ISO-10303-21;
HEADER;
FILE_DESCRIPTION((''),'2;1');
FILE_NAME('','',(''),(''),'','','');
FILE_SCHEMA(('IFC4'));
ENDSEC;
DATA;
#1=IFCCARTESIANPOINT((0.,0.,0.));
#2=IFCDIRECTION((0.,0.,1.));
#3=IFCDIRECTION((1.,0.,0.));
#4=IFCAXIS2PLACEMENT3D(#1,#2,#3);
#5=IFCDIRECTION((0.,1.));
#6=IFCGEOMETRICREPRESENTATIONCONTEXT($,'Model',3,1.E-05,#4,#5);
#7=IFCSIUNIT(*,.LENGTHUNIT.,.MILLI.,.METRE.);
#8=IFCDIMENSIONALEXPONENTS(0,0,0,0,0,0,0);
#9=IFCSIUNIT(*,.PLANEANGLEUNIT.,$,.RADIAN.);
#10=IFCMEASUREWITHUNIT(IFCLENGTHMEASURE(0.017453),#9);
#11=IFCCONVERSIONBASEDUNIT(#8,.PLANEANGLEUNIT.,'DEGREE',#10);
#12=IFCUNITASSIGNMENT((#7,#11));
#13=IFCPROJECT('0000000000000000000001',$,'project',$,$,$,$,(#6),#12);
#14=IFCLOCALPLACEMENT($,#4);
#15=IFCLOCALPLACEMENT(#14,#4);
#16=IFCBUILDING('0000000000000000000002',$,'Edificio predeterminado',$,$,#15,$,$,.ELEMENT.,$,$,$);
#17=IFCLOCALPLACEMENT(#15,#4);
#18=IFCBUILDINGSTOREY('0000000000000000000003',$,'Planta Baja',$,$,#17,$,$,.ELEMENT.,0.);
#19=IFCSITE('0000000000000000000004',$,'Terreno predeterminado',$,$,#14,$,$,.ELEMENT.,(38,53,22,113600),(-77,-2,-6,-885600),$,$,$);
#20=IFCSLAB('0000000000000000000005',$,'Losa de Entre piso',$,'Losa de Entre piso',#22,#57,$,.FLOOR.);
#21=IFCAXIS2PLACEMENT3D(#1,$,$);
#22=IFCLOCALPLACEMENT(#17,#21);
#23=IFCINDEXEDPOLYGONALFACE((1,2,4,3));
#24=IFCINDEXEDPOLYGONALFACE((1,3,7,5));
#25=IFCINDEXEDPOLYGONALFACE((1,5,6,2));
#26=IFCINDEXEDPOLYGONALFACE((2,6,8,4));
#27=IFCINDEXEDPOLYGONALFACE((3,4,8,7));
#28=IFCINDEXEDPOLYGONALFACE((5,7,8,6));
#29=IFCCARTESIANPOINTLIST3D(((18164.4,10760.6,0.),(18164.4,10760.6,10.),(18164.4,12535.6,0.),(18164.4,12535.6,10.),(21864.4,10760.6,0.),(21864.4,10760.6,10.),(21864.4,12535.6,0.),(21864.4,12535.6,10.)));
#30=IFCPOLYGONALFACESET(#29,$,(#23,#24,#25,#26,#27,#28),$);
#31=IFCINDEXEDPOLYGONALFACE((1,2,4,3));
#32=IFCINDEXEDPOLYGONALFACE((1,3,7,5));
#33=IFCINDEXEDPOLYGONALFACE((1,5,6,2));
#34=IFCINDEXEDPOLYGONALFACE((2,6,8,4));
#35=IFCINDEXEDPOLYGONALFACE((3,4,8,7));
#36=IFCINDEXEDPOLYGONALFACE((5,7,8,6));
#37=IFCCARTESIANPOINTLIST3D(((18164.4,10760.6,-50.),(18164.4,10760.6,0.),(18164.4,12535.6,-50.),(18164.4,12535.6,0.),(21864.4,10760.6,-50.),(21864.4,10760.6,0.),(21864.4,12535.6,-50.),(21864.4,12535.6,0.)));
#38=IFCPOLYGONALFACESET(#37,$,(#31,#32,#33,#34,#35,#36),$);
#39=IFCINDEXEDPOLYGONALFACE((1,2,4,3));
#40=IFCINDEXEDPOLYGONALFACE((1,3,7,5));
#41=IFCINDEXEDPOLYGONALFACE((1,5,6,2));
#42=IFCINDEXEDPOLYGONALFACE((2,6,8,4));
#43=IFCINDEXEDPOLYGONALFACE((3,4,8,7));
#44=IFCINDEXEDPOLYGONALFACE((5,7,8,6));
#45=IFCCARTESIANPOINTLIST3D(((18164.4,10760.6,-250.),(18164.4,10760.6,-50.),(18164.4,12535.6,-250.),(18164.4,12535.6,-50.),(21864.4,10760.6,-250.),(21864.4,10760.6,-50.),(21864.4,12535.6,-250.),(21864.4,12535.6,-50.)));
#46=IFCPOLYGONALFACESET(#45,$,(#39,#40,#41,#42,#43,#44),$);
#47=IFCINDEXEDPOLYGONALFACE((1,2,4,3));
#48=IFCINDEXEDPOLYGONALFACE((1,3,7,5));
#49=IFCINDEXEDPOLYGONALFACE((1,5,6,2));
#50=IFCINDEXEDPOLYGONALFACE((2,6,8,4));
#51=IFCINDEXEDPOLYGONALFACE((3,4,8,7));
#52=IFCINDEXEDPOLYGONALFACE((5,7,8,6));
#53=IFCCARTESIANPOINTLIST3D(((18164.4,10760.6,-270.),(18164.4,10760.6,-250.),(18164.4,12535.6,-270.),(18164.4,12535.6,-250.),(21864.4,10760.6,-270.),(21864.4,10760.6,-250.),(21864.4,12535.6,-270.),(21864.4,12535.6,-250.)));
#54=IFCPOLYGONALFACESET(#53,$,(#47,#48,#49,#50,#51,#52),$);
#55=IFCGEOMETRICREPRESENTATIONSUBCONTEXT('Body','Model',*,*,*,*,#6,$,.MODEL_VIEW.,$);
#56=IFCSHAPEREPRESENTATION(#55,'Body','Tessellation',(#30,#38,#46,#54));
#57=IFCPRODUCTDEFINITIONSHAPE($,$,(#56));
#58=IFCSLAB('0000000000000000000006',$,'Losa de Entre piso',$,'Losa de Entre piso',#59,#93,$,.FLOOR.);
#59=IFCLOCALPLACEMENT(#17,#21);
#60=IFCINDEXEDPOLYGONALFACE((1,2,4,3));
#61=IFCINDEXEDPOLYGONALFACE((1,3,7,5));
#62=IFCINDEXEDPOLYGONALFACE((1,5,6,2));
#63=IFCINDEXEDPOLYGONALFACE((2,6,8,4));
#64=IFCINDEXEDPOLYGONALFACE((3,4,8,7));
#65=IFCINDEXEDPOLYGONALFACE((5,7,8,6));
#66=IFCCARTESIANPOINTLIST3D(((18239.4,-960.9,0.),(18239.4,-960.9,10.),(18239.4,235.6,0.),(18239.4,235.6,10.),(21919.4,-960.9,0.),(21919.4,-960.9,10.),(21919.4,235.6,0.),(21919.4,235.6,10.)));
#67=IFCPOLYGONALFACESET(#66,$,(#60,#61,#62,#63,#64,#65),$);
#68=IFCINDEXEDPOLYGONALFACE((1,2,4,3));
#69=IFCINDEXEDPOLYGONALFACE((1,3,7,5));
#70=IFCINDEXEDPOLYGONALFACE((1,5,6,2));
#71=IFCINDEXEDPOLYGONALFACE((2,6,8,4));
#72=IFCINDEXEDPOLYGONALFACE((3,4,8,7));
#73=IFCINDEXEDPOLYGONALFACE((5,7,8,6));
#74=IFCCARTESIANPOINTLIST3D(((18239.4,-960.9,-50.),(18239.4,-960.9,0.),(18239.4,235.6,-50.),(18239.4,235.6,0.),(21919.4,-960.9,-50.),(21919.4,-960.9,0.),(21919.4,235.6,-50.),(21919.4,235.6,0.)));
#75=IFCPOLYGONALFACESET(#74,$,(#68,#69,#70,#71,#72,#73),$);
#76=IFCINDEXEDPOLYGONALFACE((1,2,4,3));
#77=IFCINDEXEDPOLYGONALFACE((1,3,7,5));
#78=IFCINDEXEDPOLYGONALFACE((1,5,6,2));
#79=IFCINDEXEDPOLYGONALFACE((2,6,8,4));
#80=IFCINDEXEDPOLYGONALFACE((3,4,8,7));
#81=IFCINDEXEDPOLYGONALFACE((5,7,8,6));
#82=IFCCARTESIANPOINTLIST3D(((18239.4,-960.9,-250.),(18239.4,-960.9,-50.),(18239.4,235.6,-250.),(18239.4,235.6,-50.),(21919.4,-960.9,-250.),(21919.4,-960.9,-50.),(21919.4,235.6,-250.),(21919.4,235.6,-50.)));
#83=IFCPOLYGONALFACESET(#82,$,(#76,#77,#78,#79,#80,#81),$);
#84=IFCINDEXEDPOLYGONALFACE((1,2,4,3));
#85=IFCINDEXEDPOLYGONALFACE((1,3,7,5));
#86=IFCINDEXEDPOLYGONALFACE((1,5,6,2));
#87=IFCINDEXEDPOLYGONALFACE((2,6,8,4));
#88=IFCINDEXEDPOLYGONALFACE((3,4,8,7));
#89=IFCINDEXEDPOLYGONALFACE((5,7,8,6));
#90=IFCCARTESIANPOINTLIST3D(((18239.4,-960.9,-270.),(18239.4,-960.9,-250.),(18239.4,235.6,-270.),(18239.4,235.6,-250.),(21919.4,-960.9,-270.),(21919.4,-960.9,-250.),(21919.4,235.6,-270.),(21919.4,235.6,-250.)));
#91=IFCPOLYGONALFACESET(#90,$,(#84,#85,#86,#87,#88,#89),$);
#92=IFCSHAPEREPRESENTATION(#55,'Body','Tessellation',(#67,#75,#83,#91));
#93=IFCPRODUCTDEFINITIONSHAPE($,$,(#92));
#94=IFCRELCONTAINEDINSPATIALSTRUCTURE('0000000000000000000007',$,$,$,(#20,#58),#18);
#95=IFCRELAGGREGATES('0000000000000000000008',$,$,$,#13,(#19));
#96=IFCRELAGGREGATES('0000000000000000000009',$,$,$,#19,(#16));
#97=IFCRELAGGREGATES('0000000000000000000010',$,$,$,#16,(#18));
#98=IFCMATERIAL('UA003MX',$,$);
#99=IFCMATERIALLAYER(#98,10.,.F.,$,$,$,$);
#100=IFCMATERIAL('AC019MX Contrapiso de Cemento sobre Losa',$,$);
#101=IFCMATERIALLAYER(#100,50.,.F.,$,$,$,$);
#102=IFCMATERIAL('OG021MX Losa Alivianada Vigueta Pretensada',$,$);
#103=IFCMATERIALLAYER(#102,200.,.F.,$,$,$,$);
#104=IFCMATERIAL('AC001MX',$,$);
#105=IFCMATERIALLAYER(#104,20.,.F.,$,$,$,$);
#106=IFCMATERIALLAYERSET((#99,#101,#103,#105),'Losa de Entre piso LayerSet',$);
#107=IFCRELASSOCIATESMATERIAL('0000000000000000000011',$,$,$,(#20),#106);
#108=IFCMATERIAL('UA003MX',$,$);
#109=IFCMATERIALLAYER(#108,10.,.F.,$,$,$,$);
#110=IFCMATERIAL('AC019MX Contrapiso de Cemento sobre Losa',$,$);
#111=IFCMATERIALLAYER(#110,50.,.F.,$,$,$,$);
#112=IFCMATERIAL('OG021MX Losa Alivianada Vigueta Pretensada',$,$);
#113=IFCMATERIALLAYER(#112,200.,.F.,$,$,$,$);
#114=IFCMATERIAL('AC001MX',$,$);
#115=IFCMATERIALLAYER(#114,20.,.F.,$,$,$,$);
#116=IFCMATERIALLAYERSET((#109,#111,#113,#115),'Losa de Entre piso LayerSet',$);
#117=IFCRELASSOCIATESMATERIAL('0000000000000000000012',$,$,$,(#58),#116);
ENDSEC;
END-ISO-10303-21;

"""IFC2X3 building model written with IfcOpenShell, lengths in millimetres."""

from ifc_helpers import new_model, entity, si_unit, converted_unit, direction, frame, origin_with_axes, place, context, subcontext, project, spatial, polyline, outline, extrude, material, layer, layer_set, layer_usage, element, save


model = new_model("IFC2X3")

# Units and contexts
model_context = context("Model", 3, precision=1e-05, world=origin_with_axes(), true_north=direction((0.0, 1.0)))
body_context = subcontext(model_context, "Body", "Model", "MODEL_VIEW")
ifc_project = project(units=[si_unit("LENGTHUNIT", "METRE", prefix="MILLI"), converted_unit("PLANEANGLEUNIT", "DEGREE", entity("IfcLengthMeasure", 0.017453), si_unit("PLANEANGLEUNIT", "RADIAN"), dimensions=[0, 0, 0, 0, 0, 0, 0])], contexts=[model_context])

# Site, building, storey
site_placement = place(None, origin_with_axes())
site = spatial("IfcSite", under=ifc_project, at=site_placement, Name="Terreno predeterminado", CompositionType="ELEMENT", RefLatitude=(38, 53, 22, 113600), RefLongitude=(-77, -2, -6, -885600))
building_placement = place(site_placement, origin_with_axes())
building = spatial("IfcBuilding", under=site, at=building_placement, Name="Edificio predeterminado", CompositionType="ELEMENT")
storey_placement = place(building_placement, origin_with_axes())
storey = spatial("IfcBuildingStorey", under=building, at=storey_placement, Name="Planta Baja", CompositionType="ELEMENT", Elevation=0.0)

# Slabs
ifc_material_1 = material(Name="UA003MX")
ifc_layer_1 = layer(ifc_material_1, 10.0, ventilated=False)
ifc_material_2 = material(Name="AC019MX Contrapiso de Cemento sobre Losa")
ifc_layer_2 = layer(ifc_material_2, 50.0, ventilated=False)
ifc_material_3 = material(Name="OG021MX Losa Alivianada Vigueta Pretensada")
ifc_layer_3 = layer(ifc_material_3, 200.0, ventilated=False)
ifc_material_4 = material(Name="AC001MX")
ifc_layer_4 = layer(ifc_material_4, 20.0, ventilated=False)
ifc_layer_set_1 = layer_set([ifc_layer_1, ifc_layer_2, ifc_layer_3, ifc_layer_4], Name="Losa de Entre piso LayerSet")
ifc_layer_usage_1 = layer_usage(ifc_layer_set_1, "AXIS3", "POSITIVE", 0.0)
slab_1_placement = place(storey_placement, origin_with_axes())
element("IfcSlab", 1, at=slab_1_placement, inside=storey, material=ifc_layer_usage_1, Name="Losa de Entre piso", ObjectType="Losa de Entre piso", PredefinedType="FLOOR", context=body_context, shape_type="SweptSolid", body=[
    extrude(outline(polyline([(0.0, 0.0), (1775.0, 0.0), (1775.0, 3700.0), (0.0, 3700.0), (0.0, 0.0)])), frame((21864.4, 12535.6, 0.0), z_axis=(0.0, 0.0, -1.0), x_axis=(0.0, -1.0, 0.0)), (0.0, 0.0, -1.0), 10.0),
    extrude(outline(polyline([(0.0, 0.0), (1775.0, 0.0), (1775.0, 3700.0), (0.0, 3700.0), (0.0, 0.0)])), frame((21864.4, 12535.6, -50.0), z_axis=(0.0, 0.0, -1.0), x_axis=(0.0, -1.0, 0.0)), (0.0, 0.0, -1.0), 50.0),
    extrude(outline(polyline([(0.0, 0.0), (1775.0, 0.0), (1775.0, 3700.0), (0.0, 3700.0), (0.0, 0.0)])), frame((21864.4, 12535.6, -250.0), z_axis=(0.0, 0.0, -1.0), x_axis=(0.0, -1.0, 0.0)), (0.0, 0.0, -1.0), 200.0),
    extrude(outline(polyline([(0.0, 0.0), (1775.0, 0.0), (1775.0, 3700.0), (0.0, 3700.0), (0.0, 0.0)])), frame((21864.4, 12535.6, -270.0), z_axis=(0.0, 0.0, -1.0), x_axis=(0.0, -1.0, 0.0)), (0.0, 0.0, -1.0), 20.0),
])
ifc_material_5 = material(Name="UA003MX")
ifc_layer_5 = layer(ifc_material_5, 10.0, ventilated=False)
ifc_material_6 = material(Name="AC019MX Contrapiso de Cemento sobre Losa")
ifc_layer_6 = layer(ifc_material_6, 50.0, ventilated=False)
ifc_material_7 = material(Name="OG021MX Losa Alivianada Vigueta Pretensada")
ifc_layer_7 = layer(ifc_material_7, 200.0, ventilated=False)
ifc_material_8 = material(Name="AC001MX")
ifc_layer_8 = layer(ifc_material_8, 20.0, ventilated=False)
ifc_layer_set_2 = layer_set([ifc_layer_5, ifc_layer_6, ifc_layer_7, ifc_layer_8], Name="Losa de Entre piso LayerSet")
ifc_layer_usage_2 = layer_usage(ifc_layer_set_2, "AXIS3", "POSITIVE", 0.0)
slab_2_placement = place(storey_placement, origin_with_axes())
element("IfcSlab", 2, at=slab_2_placement, inside=storey, material=ifc_layer_usage_2, Name="Losa de Entre piso", ObjectType="Losa de Entre piso", PredefinedType="FLOOR", context=body_context, shape_type="SweptSolid", body=[
    extrude(outline(polyline([(0.0, 0.0), (1196.6, 0.0), (1196.6, 3680.0), (0.0, 3680.0), (0.0, 0.0)])), frame((21919.4, 235.6, 0.0), z_axis=(0.0, 0.0, -1.0), x_axis=(0.0, -1.0, 0.0)), (0.0, 0.0, -1.0), 10.0),
    extrude(outline(polyline([(0.0, 0.0), (1196.6, 0.0), (1196.6, 3680.0), (0.0, 3680.0), (0.0, 0.0)])), frame((21919.4, 235.6, -50.0), z_axis=(0.0, 0.0, -1.0), x_axis=(0.0, -1.0, 0.0)), (0.0, 0.0, -1.0), 50.0),
    extrude(outline(polyline([(0.0, 0.0), (1196.6, 0.0), (1196.6, 3680.0), (0.0, 3680.0), (0.0, 0.0)])), frame((21919.4, 235.6, -250.0), z_axis=(0.0, 0.0, -1.0), x_axis=(0.0, -1.0, 0.0)), (0.0, 0.0, -1.0), 200.0),
    extrude(outline(polyline([(0.0, 0.0), (1196.6, 0.0), (1196.6, 3680.0), (0.0, 3680.0), (0.0, 0.0)])), frame((21919.4, 235.6, -270.0), z_axis=(0.0, 0.0, -1.0), x_axis=(0.0, -1.0, 0.0)), (0.0, 0.0, -1.0), 20.0),
])

save(model, "model.ifc")
